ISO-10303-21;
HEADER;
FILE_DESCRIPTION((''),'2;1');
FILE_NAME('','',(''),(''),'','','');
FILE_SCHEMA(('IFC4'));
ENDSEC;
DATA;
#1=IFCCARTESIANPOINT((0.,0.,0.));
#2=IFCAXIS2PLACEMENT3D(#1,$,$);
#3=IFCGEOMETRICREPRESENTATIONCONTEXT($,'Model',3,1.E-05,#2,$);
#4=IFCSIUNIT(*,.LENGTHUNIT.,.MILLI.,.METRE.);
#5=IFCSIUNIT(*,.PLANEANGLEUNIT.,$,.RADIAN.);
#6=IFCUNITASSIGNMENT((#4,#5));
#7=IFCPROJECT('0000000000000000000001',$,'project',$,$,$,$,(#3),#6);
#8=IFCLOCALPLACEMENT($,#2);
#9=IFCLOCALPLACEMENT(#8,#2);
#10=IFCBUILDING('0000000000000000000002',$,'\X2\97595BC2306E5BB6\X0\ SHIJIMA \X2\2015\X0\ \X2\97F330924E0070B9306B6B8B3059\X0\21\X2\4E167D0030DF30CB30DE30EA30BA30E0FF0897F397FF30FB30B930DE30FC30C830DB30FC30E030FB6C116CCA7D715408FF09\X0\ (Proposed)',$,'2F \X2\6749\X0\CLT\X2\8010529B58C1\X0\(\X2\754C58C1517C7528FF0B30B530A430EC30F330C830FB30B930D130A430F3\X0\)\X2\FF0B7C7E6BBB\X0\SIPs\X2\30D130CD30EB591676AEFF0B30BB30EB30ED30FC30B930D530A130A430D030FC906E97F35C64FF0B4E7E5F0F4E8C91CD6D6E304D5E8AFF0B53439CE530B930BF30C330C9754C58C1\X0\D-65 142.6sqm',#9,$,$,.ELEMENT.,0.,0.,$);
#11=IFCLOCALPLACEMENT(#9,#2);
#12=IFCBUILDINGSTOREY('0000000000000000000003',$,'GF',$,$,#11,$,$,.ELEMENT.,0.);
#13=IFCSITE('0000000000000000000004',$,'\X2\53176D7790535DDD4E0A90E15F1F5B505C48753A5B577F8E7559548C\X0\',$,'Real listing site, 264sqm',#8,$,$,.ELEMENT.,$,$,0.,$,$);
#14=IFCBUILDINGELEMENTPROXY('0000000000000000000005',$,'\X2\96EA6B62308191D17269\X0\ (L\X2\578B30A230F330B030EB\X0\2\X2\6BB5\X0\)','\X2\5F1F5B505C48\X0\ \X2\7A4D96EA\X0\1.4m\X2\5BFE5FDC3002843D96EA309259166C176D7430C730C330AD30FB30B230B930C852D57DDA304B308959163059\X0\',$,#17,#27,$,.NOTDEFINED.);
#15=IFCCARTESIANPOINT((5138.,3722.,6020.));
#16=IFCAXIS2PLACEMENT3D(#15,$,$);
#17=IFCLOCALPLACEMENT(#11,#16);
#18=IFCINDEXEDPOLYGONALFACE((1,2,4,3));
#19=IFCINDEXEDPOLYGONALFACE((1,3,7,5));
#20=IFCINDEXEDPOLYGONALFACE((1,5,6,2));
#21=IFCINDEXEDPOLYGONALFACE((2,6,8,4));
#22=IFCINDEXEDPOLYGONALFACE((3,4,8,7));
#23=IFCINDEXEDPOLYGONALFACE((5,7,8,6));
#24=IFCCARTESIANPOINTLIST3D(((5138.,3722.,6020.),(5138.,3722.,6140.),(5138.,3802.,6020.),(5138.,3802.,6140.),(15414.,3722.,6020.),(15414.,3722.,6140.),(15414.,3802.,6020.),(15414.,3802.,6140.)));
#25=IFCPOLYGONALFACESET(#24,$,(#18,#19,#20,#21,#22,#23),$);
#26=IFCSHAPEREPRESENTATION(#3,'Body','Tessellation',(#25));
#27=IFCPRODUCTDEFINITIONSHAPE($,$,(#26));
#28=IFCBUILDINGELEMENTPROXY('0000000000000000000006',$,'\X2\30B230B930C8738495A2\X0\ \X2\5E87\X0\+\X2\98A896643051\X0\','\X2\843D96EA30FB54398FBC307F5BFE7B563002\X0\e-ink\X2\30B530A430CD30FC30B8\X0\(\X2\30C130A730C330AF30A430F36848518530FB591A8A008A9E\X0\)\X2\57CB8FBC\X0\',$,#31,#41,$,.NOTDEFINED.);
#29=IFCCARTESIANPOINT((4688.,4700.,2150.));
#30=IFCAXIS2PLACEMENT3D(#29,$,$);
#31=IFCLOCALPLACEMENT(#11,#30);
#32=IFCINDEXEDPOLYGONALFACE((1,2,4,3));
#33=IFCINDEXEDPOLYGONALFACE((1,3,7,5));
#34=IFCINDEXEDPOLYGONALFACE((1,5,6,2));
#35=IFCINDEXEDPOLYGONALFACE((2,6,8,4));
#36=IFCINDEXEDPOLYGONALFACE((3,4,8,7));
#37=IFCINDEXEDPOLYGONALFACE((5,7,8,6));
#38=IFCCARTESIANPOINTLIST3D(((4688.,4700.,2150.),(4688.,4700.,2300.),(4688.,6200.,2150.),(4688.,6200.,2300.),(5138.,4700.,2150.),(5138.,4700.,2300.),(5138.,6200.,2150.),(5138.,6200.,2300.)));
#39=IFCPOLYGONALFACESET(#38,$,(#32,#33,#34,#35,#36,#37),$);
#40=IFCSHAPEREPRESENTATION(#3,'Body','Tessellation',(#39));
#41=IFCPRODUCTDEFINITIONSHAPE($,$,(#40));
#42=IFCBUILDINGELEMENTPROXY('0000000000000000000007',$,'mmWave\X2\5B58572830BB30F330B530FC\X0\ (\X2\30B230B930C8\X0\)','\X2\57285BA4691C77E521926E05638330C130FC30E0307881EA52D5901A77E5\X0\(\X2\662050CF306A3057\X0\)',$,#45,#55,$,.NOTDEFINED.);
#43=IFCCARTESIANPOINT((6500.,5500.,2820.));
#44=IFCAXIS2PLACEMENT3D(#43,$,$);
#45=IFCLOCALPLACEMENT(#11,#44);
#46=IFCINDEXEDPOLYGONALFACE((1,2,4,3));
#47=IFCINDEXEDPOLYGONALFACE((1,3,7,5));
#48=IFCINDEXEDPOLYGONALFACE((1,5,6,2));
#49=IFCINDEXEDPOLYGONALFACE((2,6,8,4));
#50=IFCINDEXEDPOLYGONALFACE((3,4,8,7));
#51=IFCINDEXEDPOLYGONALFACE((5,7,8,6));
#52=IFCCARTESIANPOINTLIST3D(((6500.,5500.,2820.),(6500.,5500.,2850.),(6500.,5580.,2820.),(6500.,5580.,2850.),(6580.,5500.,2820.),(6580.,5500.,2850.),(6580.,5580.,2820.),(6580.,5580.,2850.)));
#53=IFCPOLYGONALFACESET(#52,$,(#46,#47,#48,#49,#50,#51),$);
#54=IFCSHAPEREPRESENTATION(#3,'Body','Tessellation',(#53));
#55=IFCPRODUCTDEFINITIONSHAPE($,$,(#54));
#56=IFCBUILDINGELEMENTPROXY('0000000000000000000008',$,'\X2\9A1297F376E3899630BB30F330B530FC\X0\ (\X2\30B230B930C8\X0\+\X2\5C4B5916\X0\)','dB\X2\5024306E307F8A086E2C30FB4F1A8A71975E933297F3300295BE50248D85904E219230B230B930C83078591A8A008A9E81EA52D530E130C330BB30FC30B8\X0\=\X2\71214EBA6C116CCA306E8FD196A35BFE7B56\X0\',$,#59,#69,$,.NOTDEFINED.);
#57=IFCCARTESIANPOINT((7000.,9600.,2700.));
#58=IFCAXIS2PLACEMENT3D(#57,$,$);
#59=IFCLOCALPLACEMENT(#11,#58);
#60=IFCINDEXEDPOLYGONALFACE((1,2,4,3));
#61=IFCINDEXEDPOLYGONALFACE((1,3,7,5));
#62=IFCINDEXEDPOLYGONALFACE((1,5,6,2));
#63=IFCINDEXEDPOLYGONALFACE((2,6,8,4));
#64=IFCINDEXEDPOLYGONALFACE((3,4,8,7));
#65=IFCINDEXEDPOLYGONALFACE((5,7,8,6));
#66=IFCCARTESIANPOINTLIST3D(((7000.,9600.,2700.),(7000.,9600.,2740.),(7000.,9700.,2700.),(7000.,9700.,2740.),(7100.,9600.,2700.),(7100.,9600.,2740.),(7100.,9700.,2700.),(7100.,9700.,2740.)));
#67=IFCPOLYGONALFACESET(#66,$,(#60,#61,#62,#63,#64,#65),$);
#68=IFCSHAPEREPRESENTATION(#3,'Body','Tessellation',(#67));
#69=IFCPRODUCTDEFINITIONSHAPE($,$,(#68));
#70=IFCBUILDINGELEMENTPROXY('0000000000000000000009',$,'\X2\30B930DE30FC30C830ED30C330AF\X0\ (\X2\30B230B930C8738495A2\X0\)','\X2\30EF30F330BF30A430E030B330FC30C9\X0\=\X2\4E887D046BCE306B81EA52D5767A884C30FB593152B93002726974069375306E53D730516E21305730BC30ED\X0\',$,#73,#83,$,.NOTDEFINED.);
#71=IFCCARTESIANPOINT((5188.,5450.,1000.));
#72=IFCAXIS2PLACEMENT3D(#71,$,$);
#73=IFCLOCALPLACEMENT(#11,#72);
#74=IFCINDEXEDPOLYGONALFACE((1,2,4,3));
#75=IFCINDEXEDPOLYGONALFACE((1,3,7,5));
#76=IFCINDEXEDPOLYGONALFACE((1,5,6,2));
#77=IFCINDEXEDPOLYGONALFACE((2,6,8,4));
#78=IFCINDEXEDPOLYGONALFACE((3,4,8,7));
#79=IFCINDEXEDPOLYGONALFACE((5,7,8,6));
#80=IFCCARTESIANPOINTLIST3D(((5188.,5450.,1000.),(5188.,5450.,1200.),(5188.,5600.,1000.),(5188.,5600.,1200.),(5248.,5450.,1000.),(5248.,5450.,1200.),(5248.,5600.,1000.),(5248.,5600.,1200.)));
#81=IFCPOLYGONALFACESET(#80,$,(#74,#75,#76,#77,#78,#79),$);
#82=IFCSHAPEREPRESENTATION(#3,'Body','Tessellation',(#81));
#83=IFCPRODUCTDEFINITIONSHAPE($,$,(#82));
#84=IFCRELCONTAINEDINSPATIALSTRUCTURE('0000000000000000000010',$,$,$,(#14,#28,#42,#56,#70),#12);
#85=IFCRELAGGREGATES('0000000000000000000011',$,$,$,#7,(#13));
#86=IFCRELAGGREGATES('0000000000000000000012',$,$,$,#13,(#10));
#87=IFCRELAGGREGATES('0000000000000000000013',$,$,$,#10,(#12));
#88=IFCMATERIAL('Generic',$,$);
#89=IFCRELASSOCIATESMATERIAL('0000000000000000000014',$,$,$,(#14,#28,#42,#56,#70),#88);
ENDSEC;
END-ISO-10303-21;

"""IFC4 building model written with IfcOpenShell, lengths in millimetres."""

from ifc_helpers import new_model, si_unit, frame, frame_2d, origin, place, context, project, spatial, rectangle, extrude, material, element, save


model = new_model("IFC4")

# Units and contexts
model_context = context("Model", 3, precision=1e-05, world=origin())
ifc_project = project(units=[si_unit("LENGTHUNIT", "METRE", prefix="MILLI"), si_unit("PLANEANGLEUNIT", "RADIAN")], contexts=[model_context])

# Site, building, storey
site_placement = place(None, origin())
site = spatial("IfcSite", under=ifc_project, at=site_placement, Name="北海道川上郡弟子屈町字美留和", ObjectType="Real listing site, 264sqm", CompositionType="ELEMENT", RefElevation=0.0)
building_placement = place(site_placement, origin())
building = spatial("IfcBuilding", under=site, at=building_placement, Name="静寂の家 SHIJIMA ― 音を一点に残す21世紀ミニマリズム（音響・スマートホーム・民泊統合） (Proposed)", ObjectType="2F 杉CLT耐力壁(界壁兼用＋サイレント・スパイン)＋籾殻SIPsパネル外皮＋セルロースファイバー遮音層＋乾式二重浮き床＋千鳥スタッド界壁D-65 142.6sqm", CompositionType="ELEMENT", ElevationOfRefHeight=0.0, ElevationOfTerrain=0.0)
storey_placement = place(building_placement, origin())
storey = spatial("IfcBuildingStorey", under=building, at=storey_placement, Name="GF", CompositionType="ELEMENT", Elevation=0.0)

# Shared definitions
ifc_material = material(Name="Generic")

# Building element proxies
proxy_1_placement = place(storey_placement, frame((5138.0, 3722.0, 6020.0)))
element("IfcBuildingElementProxy", 1, at=proxy_1_placement, inside=storey, material=ifc_material, Name="雪止め金物 (L型アングル2段)", Description="弟子屈 積雪1.4m対応。落雪を外気浴デッキ・ゲスト動線から外す", PredefinedType="NOTDEFINED", context=model_context, shape_type="SweptSolid", body=[
    extrude(rectangle(XDim=10276.0, YDim=80.0, at=frame_2d((5138.0, 40.0))), frame((5138.0, 3722.0, 6020.0)), (0.0, 0.0, 1.0), 120.0),
])
proxy_2_placement = place(storey_placement, frame((4688.0, 4700.0, 2150.0)))
element("IfcBuildingElementProxy", 2, at=proxy_2_placement, inside=storey, material=ifc_material, Name="ゲスト玄関 庇+風除け", Description="落雪・吹込み対策。e-inkサイネージ(チェックイン案内・多言語)埋込", PredefinedType="NOTDEFINED", context=model_context, shape_type="SweptSolid", body=[
    extrude(rectangle(XDim=450.0, YDim=1500.0, at=frame_2d((225.0, 750.0))), frame((4688.0, 4700.0, 2150.0)), (0.0, 0.0, 1.0), 150.0),
])
proxy_3_placement = place(storey_placement, frame((6500.0, 5500.0, 2820.0)))
element("IfcBuildingElementProxy", 3, at=proxy_3_placement, inside=storey, material=ifc_material, Name="mmWave存在センサー (ゲスト)", Description="在室検知→清掃チームへ自動通知(映像なし)", PredefinedType="NOTDEFINED", context=model_context, shape_type="SweptSolid", body=[
    extrude(rectangle(XDim=80.0, YDim=80.0, at=frame_2d((40.0, 40.0))), frame((6500.0, 5500.0, 2820.0)), (0.0, 0.0, 1.0), 30.0),
])
proxy_4_placement = place(storey_placement, frame((7000.0, 9600.0, 2700.0)))
element("IfcBuildingElementProxy", 4, at=proxy_4_placement, inside=storey, material=ifc_material, Name="騒音監視センサー (ゲスト+屋外)", Description="dB値のみ計測・会話非録音。閾値超過→ゲストへ多言語自動メッセージ=無人民泊の近隣対策", PredefinedType="NOTDEFINED", context=model_context, shape_type="SweptSolid", body=[
    extrude(rectangle(XDim=100.0, YDim=100.0, at=frame_2d((50.0, 50.0))), frame((7000.0, 9600.0, 2700.0)), (0.0, 0.0, 1.0), 40.0),
])
proxy_5_placement = place(storey_placement, frame((5188.0, 5450.0, 1000.0)))
element("IfcBuildingElementProxy", 5, at=proxy_5_placement, inside=storey, material=ifc_material, Name="スマートロック (ゲスト玄関)", Description="ワンタイムコード=予約毎に自動発行・失効。物理鍵の受け渡しゼロ", PredefinedType="NOTDEFINED", context=model_context, shape_type="SweptSolid", body=[
    extrude(rectangle(XDim=60.0, YDim=150.0, at=frame_2d((30.0, 75.0))), frame((5188.0, 5450.0, 1000.0)), (0.0, 0.0, 1.0), 200.0),
])

save(model, "model.ifc")
